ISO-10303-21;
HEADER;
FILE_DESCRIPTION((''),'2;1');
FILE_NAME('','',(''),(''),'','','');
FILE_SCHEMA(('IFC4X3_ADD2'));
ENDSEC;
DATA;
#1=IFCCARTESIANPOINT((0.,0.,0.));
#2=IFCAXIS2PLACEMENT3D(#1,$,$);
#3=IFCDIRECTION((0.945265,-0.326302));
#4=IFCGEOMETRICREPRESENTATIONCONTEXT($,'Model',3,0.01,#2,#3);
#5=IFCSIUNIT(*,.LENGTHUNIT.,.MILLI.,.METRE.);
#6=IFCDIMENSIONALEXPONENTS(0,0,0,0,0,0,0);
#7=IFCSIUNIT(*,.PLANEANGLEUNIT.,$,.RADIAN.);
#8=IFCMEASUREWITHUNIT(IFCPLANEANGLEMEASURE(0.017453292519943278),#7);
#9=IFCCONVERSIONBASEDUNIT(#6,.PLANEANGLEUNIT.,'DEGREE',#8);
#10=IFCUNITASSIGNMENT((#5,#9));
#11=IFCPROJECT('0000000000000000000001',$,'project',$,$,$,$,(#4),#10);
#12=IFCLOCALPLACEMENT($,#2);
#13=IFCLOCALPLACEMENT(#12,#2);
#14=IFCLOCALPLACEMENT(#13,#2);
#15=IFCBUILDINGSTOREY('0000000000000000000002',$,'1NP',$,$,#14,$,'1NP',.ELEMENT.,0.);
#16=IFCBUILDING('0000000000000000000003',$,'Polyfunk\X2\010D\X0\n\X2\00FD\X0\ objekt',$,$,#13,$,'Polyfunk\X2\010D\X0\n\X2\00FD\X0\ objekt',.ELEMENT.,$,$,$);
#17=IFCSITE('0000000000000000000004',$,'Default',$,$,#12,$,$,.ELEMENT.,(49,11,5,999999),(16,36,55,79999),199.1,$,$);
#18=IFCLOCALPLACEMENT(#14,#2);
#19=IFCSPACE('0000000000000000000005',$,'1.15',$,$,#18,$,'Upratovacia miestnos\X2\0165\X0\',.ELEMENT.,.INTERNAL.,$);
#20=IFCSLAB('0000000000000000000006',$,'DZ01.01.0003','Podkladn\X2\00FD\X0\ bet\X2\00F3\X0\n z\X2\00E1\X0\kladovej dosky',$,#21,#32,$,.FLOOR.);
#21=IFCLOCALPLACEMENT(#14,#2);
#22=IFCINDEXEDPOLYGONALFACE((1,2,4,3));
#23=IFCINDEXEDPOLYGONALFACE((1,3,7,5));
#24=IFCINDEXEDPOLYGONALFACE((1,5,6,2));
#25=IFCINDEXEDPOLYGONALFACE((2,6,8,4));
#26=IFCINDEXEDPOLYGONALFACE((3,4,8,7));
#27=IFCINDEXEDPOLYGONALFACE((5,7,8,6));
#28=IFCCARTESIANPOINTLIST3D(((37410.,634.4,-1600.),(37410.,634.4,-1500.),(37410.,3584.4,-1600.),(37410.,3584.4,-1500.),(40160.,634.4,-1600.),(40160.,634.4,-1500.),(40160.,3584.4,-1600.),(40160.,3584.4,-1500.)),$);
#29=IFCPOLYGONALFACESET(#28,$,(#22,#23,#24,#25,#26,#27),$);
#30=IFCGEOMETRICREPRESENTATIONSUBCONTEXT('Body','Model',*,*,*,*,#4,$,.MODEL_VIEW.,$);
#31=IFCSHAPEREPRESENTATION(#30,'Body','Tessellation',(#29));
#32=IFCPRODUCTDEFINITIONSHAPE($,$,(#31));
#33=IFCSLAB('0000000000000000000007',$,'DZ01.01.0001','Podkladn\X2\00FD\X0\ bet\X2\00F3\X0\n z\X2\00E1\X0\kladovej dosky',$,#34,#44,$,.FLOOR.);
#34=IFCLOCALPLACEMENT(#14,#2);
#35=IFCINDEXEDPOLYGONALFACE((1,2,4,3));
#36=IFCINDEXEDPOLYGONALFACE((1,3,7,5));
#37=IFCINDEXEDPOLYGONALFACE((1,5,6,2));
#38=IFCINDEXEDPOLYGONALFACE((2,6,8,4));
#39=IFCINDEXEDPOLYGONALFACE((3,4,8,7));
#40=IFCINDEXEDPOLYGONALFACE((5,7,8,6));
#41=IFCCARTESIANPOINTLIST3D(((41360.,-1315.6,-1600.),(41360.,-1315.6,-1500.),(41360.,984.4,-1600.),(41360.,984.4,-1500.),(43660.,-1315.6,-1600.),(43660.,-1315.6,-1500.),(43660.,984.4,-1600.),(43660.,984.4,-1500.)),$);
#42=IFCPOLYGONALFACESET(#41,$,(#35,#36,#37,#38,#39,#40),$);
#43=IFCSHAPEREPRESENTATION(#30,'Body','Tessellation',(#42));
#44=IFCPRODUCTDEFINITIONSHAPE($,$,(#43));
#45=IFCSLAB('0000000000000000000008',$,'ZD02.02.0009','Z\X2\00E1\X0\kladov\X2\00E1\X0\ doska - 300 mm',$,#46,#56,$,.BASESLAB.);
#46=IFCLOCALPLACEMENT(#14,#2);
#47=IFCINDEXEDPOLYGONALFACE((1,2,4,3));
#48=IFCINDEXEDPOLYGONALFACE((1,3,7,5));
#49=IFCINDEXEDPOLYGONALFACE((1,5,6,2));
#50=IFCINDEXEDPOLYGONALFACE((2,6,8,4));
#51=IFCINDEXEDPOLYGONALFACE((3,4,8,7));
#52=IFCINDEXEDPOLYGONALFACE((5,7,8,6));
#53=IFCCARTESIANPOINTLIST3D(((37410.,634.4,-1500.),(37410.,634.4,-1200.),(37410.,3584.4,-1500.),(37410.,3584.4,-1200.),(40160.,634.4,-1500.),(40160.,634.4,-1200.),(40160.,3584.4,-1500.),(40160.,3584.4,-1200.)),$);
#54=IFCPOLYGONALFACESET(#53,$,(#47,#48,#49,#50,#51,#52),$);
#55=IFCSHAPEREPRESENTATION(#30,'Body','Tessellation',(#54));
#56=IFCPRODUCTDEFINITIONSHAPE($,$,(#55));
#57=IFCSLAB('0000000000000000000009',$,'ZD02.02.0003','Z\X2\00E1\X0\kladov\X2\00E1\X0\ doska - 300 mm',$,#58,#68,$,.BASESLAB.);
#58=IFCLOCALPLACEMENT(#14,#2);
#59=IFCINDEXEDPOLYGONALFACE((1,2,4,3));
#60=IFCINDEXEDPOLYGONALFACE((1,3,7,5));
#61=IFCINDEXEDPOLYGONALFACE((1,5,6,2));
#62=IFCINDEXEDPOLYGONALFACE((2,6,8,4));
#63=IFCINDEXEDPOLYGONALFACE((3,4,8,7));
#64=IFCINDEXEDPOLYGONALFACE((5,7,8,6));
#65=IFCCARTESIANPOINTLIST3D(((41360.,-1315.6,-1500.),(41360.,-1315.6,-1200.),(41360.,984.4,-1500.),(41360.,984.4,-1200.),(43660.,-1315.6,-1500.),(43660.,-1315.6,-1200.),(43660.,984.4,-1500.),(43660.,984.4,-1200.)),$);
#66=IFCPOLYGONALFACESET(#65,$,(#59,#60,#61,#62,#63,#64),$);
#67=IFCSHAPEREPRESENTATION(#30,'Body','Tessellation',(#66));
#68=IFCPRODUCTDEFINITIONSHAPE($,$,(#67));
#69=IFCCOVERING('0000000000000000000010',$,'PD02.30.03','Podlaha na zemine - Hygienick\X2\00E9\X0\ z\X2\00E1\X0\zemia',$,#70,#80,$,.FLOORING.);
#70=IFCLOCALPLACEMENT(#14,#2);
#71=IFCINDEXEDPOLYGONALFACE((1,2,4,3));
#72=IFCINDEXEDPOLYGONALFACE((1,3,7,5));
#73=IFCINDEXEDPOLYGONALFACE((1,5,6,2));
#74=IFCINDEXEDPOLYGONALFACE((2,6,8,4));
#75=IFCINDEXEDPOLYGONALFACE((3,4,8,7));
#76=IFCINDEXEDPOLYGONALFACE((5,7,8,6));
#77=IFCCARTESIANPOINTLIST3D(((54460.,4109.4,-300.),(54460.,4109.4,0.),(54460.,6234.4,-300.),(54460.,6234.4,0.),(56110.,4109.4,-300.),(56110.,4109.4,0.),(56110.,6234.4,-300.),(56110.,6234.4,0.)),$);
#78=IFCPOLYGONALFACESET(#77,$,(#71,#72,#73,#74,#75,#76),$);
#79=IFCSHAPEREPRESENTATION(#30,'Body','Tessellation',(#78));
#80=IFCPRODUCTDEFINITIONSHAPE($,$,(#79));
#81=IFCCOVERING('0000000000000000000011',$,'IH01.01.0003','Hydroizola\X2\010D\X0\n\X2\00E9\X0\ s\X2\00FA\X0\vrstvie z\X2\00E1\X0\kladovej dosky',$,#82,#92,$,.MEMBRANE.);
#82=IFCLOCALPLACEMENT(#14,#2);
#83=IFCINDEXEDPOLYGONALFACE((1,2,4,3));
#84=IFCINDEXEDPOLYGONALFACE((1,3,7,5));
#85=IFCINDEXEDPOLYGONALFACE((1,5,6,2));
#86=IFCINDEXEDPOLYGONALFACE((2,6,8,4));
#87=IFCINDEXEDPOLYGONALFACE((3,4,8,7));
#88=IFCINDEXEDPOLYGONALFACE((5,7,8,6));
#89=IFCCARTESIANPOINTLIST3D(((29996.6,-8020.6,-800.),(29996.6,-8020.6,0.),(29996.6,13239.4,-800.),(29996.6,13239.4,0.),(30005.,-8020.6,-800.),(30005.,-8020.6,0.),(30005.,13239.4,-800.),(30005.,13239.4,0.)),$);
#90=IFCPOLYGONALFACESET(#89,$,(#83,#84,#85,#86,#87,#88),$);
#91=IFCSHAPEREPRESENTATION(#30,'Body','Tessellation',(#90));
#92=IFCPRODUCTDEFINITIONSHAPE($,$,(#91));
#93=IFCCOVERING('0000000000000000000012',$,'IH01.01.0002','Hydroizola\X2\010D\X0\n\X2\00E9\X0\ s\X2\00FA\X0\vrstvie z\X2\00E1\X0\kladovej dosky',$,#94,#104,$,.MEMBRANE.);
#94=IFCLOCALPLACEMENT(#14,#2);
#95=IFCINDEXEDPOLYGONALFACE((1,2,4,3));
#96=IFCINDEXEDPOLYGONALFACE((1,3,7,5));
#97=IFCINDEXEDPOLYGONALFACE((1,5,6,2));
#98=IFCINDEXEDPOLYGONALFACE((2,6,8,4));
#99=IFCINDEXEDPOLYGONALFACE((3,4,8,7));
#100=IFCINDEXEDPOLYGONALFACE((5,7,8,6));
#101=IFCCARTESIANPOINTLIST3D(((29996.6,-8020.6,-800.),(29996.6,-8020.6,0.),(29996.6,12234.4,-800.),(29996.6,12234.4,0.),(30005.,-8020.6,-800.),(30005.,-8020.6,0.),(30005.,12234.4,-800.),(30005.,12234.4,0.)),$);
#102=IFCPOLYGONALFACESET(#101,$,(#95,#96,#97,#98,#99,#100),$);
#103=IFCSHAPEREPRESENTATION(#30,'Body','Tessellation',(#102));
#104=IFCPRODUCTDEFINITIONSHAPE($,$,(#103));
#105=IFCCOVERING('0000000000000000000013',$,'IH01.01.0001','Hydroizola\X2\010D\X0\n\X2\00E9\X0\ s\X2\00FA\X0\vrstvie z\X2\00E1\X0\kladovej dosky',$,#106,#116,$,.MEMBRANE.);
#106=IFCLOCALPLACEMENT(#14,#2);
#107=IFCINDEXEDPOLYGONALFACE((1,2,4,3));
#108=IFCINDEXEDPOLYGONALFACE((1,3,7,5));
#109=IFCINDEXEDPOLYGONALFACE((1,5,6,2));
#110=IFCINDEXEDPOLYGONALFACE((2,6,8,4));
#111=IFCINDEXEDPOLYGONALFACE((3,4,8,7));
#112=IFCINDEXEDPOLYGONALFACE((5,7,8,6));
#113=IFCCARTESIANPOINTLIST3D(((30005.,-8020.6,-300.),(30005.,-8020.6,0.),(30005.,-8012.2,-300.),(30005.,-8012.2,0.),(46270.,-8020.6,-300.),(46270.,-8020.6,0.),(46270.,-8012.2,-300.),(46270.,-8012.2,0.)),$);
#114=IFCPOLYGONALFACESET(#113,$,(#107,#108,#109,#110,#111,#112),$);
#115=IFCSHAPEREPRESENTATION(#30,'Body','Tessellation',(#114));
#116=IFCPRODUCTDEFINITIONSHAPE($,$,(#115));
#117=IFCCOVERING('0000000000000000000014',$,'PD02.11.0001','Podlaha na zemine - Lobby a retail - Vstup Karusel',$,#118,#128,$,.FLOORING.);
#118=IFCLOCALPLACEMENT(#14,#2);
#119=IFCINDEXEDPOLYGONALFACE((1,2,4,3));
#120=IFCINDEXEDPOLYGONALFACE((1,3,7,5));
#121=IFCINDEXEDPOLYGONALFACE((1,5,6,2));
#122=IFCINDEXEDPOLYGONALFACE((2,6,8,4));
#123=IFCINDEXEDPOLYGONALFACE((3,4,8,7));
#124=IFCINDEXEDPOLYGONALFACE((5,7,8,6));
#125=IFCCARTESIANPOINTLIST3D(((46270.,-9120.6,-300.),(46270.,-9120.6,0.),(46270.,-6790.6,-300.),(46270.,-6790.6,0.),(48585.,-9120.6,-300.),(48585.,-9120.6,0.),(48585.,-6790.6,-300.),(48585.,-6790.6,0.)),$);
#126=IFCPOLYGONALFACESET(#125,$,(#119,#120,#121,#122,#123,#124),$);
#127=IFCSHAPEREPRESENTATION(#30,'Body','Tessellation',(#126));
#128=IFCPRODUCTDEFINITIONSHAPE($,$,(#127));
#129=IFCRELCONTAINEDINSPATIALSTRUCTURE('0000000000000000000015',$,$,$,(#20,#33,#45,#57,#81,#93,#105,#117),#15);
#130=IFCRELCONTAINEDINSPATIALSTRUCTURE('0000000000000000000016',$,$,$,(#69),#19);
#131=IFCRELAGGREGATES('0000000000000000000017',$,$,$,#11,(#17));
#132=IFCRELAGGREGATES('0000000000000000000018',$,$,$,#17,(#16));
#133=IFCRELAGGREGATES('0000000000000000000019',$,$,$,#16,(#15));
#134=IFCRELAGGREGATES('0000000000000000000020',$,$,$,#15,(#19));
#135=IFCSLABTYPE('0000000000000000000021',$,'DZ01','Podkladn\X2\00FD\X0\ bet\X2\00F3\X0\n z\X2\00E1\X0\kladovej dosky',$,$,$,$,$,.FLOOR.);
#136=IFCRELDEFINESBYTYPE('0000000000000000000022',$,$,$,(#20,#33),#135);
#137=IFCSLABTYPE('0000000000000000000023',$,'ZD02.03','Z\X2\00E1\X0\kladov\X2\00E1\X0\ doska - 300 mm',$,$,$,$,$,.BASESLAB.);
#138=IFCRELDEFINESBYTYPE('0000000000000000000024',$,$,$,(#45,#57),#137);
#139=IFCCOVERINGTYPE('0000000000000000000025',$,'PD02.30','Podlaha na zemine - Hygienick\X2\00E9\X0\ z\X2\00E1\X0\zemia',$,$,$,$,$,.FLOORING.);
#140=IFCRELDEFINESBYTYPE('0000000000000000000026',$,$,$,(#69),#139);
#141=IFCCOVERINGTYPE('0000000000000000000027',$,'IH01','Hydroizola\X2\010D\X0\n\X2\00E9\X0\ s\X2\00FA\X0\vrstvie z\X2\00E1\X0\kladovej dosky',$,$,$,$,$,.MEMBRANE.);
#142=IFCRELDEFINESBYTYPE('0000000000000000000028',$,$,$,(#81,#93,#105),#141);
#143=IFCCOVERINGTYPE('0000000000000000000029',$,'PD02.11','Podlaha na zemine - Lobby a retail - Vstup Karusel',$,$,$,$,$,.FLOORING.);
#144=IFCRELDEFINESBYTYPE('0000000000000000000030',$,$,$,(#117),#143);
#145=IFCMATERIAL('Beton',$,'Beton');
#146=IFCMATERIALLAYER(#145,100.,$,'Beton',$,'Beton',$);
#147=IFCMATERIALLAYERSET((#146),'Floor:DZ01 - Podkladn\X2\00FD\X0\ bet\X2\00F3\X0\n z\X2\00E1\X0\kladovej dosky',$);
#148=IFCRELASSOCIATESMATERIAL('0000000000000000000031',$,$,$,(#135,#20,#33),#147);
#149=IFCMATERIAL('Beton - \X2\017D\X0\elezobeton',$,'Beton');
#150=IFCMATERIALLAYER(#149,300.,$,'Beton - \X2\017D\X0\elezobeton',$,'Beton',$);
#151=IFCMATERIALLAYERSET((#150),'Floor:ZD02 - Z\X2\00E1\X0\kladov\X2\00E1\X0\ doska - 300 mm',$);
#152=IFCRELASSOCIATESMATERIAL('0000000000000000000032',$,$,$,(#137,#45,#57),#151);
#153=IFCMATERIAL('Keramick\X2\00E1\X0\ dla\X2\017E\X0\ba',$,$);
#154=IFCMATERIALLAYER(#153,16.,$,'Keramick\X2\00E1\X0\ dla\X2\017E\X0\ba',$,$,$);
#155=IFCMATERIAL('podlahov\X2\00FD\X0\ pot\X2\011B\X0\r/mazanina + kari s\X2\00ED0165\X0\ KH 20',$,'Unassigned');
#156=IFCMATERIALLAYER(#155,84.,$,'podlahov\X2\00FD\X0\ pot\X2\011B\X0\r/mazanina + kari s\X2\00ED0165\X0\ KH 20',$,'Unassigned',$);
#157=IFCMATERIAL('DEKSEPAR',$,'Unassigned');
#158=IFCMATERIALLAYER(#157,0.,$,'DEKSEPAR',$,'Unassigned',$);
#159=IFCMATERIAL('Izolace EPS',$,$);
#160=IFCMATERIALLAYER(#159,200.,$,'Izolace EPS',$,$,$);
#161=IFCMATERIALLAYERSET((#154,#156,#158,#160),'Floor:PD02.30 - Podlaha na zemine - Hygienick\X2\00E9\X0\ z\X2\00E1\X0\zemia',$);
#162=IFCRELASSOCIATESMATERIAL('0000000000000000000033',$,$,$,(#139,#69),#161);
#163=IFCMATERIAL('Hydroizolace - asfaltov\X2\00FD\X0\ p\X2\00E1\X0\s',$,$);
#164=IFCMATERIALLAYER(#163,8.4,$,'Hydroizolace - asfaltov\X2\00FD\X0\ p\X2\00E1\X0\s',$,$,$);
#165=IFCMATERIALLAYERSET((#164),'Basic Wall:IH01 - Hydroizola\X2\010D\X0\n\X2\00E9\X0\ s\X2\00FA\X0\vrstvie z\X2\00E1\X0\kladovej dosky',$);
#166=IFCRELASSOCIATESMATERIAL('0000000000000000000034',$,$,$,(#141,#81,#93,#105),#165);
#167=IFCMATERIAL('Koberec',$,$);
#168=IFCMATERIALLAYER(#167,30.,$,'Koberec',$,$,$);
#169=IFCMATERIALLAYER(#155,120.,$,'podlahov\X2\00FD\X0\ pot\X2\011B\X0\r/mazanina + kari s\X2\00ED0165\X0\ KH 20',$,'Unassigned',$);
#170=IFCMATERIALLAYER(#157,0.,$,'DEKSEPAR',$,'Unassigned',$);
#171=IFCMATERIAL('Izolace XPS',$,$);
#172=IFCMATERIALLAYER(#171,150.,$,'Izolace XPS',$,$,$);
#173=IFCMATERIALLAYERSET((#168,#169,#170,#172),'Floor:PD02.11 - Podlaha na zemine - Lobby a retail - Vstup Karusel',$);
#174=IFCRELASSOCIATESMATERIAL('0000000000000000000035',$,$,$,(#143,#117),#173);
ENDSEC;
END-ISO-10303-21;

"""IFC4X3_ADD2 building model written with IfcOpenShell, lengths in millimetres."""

from ifc_helpers import new_model, entity, si_unit, converted_unit, direction, frame, frame_2d, origin, place, context, subcontext, project, spatial, rectangle, extrude, material, layer, layer_set, layer_usage, type_object, element, save


model = new_model("IFC4X3_ADD2")

# Units and contexts
model_context = context("Model", 3, precision=0.01, world=origin(), true_north=direction((0.945265, -0.326302)))
body_context = subcontext(model_context, "Body", "Model", "MODEL_VIEW")
ifc_project = project(units=[si_unit("LENGTHUNIT", "METRE", prefix="MILLI"), converted_unit("PLANEANGLEUNIT", "DEGREE", entity("IfcPlaneAngleMeasure", 0.017453292519943278), si_unit("PLANEANGLEUNIT", "RADIAN"), dimensions=[0, 0, 0, 0, 0, 0, 0])], contexts=[model_context])

# Site, building, storey
site_placement = place(None, origin())
site = spatial("IfcSite", under=ifc_project, at=site_placement, Name="Default", CompositionType="ELEMENT", RefLatitude=(49, 11, 5, 999999), RefLongitude=(16, 36, 55, 79999), RefElevation=199.1)
building_placement = place(site_placement, origin())
building = spatial("IfcBuilding", under=site, at=building_placement, Name="Polyfunkčný objekt", LongName="Polyfunkčný objekt", CompositionType="ELEMENT")
storey_placement = place(building_placement, origin())
storey = spatial("IfcBuildingStorey", under=building, at=storey_placement, Name="1NP", LongName="1NP", CompositionType="ELEMENT", Elevation=0.0)

# Shared definitions
ifc_material_1 = material(Name="Beton", Category="Beton")
ifc_layer_1 = layer(ifc_material_1, 100.0, Name="Beton", Category="Beton")
ifc_layer_set_1 = layer_set([ifc_layer_1], Name="Floor:DZ01 - Podkladný betón základovej dosky")
slab_type_1 = type_object("IfcSlabType", Name="DZ01", Description="Podkladný betón základovej dosky", PredefinedType="FLOOR", material=ifc_layer_set_1)

# Slabs
ifc_layer_usage_1 = layer_usage(ifc_layer_set_1, "AXIS3", "POSITIVE", 0.0)
slab_1_placement = place(storey_placement, origin())
element("IfcSlab", 1, at=slab_1_placement, inside=storey, type_object=slab_type_1, material=ifc_layer_usage_1, Name="DZ01.01.0003", Description="Podkladný betón základovej dosky", PredefinedType="FLOOR", context=body_context, shape_type="SweptSolid", body=[
    extrude(rectangle(XDim=2950.0, YDim=2750.0, at=frame_2d((0.0, 0.0), x_axis=(1.0, 0.0))), frame((38785.0, 2109.4, -1500.0), z_axis=(0.0, 0.0, -1.0), x_axis=(0.0, 1.0, 0.0)), (0.0, 0.0, 1.0), 100.0),
])
ifc_layer_usage_2 = layer_usage(ifc_layer_set_1, "AXIS3", "POSITIVE", 0.0)
slab_2_placement = place(storey_placement, origin())
element("IfcSlab", 2, at=slab_2_placement, inside=storey, type_object=slab_type_1, material=ifc_layer_usage_2, Name="DZ01.01.0001", Description="Podkladný betón základovej dosky", PredefinedType="FLOOR", context=body_context, shape_type="SweptSolid", body=[
    extrude(rectangle(XDim=2300.0, YDim=2300.0, at=frame_2d((0.0, 0.0), x_axis=(1.0, 0.0))), frame((42510.0, -165.6, -1500.0), z_axis=(0.0, 0.0, -1.0), x_axis=(0.0, 1.0, 0.0)), (0.0, 0.0, 1.0), 100.0),
])
ifc_material_2 = material(Name="Beton - Železobeton", Category="Beton")
ifc_layer_2 = layer(ifc_material_2, 300.0, Name="Beton - Železobeton", Category="Beton")
ifc_layer_set_2 = layer_set([ifc_layer_2], Name="Floor:ZD02 - Základová doska - 300 mm")
ifc_layer_usage_3 = layer_usage(ifc_layer_set_2, "AXIS3", "POSITIVE", 0.0)
slab_type_2 = type_object("IfcSlabType", Name="ZD02.03", Description="Základová doska - 300 mm", PredefinedType="BASESLAB", material=ifc_layer_set_2)
slab_3_placement = place(storey_placement, origin())
element("IfcSlab", 3, at=slab_3_placement, inside=storey, type_object=slab_type_2, material=ifc_layer_usage_3, Name="ZD02.02.0009", Description="Základová doska - 300 mm", PredefinedType="BASESLAB", context=body_context, shape_type="SweptSolid", body=[
    extrude(rectangle(XDim=2950.0, YDim=2750.0, at=frame_2d((0.0, 0.0), x_axis=(1.0, 0.0))), frame((38785.0, 2109.4, -1200.0), z_axis=(0.0, 0.0, -1.0), x_axis=(0.0, 1.0, 0.0)), (0.0, 0.0, 1.0), 300.0),
])
ifc_layer_usage_4 = layer_usage(ifc_layer_set_2, "AXIS3", "POSITIVE", 0.0)
slab_4_placement = place(storey_placement, origin())
element("IfcSlab", 4, at=slab_4_placement, inside=storey, type_object=slab_type_2, material=ifc_layer_usage_4, Name="ZD02.02.0003", Description="Základová doska - 300 mm", PredefinedType="BASESLAB", context=body_context, shape_type="SweptSolid", body=[
    extrude(rectangle(XDim=2300.0, YDim=2300.0, at=frame_2d((0.0, 0.0), x_axis=(1.0, 0.0))), frame((42510.0, -165.6, -1200.0), z_axis=(0.0, 0.0, -1.0), x_axis=(0.0, 1.0, 0.0)), (0.0, 0.0, 1.0), 300.0),
])

# Shared definitions
ifc_material_3 = material(Name="podlahový potěr/mazanina + kari síť KH 20", Category="Unassigned")
ifc_material_4 = material(Name="DEKSEPAR", Category="Unassigned")
ifc_material_5 = material(Name="Izolace EPS")

# Shared definitions
ifc_material_6 = material(Name="Keramická dlažba")
ifc_layer_3 = layer(ifc_material_6, 16.0, Name="Keramická dlažba")
ifc_layer_4 = layer(ifc_material_3, 84.0, Name="podlahový potěr/mazanina + kari síť KH 20", Category="Unassigned")
ifc_layer_5 = layer(ifc_material_4, 0.0, Name="DEKSEPAR", Category="Unassigned")
ifc_layer_6 = layer(ifc_material_5, 200.0, Name="Izolace EPS")
ifc_layer_set_3 = layer_set([ifc_layer_3, ifc_layer_4, ifc_layer_5, ifc_layer_6], Name="Floor:PD02.30 - Podlaha na zemine - Hygienické zázemia")
covering_type_1 = type_object("IfcCoveringType", Name="PD02.30", Description="Podlaha na zemine - Hygienické zázemia", PredefinedType="FLOORING", material=ifc_layer_set_3)

# Shared definitions
space_1_placement = place(storey_placement, origin())
space_1 = spatial("IfcSpace", under=storey, at=space_1_placement, Name="1.15", LongName="Upratovacia miestnosť", CompositionType="ELEMENT", PredefinedType="INTERNAL")

# Covering
ifc_layer_usage_5 = layer_usage(ifc_layer_set_3, "AXIS3", "POSITIVE", 0.0)
covering_1_placement = place(storey_placement, origin())
element("IfcCovering", 5, at=covering_1_placement, inside=space_1, type_object=covering_type_1, material=ifc_layer_usage_5, Name="PD02.30.03", Description="Podlaha na zemine - Hygienické zázemia", PredefinedType="FLOORING", context=body_context, shape_type="SweptSolid", body=[
    extrude(rectangle(XDim=2125.0, YDim=1650.0, at=frame_2d((0.0, 0.0), x_axis=(1.0, 0.0))), frame((55285.0, 5171.9, 0.0), z_axis=(0.0, 0.0, -1.0), x_axis=(0.0, 1.0, 0.0)), (0.0, 0.0, 1.0), 300.0),
])

# Coverings
ifc_material_7 = material(Name="Hydroizolace - asfaltový pás")
ifc_layer_7 = layer(ifc_material_7, 8.4, Name="Hydroizolace - asfaltový pás")
ifc_layer_set_4 = layer_set([ifc_layer_7], Name="Basic Wall:IH01 - Hydroizolačné súvrstvie základovej dosky")
covering_type_2 = type_object("IfcCoveringType", Name="IH01", Description="Hydroizolačné súvrstvie základovej dosky", PredefinedType="MEMBRANE", material=ifc_layer_set_4)
covering_2_placement = place(storey_placement, frame((30000.8, -8020.6, -800.0), z_axis=(0.0, 0.0, 1.0), x_axis=(0.0, 1.0, 0.0)))
element("IfcCovering", 6, at=covering_2_placement, inside=storey, type_object=covering_type_2, material=ifc_layer_set_4, Name="IH01.01.0003", Description="Hydroizolačné súvrstvie základovej dosky", PredefinedType="MEMBRANE", context=body_context, shape_type="SweptSolid", body=[
    extrude(rectangle(XDim=21260.0, YDim=8.4, at=frame_2d((10630.0, 0.0), x_axis=(-1.0, 0.0))), origin(), (0.0, 0.0, 1.0), 800.0),
])
covering_3_placement = place(storey_placement, frame((30000.8, -8020.6, -800.0), z_axis=(0.0, 0.0, 1.0), x_axis=(0.0, 1.0, 0.0)))
element("IfcCovering", 7, at=covering_3_placement, inside=storey, type_object=covering_type_2, material=ifc_layer_set_4, Name="IH01.01.0002", Description="Hydroizolačné súvrstvie základovej dosky", PredefinedType="MEMBRANE", context=body_context, shape_type="SweptSolid", body=[
    extrude(rectangle(XDim=20255.0, YDim=8.4, at=frame_2d((10127.5, 0.0), x_axis=(-1.0, 0.0))), origin(), (0.0, 0.0, 1.0), 800.0),
])
covering_4_placement = place(storey_placement, frame((30005.0, -8016.4, -300.0)))
element("IfcCovering", 8, at=covering_4_placement, inside=storey, type_object=covering_type_2, material=ifc_layer_set_4, Name="IH01.01.0001", Description="Hydroizolačné súvrstvie základovej dosky", PredefinedType="MEMBRANE", context=body_context, shape_type="SweptSolid", body=[
    extrude(rectangle(XDim=16265.0, YDim=8.4, at=frame_2d((8132.5, 0.0), x_axis=(-1.0, 0.0))), origin(), (0.0, 0.0, 1.0), 300.0),
])
ifc_material_8 = material(Name="Koberec")
ifc_layer_8 = layer(ifc_material_8, 30.0, Name="Koberec")
ifc_layer_9 = layer(ifc_material_3, 120.0, Name="podlahový potěr/mazanina + kari síť KH 20", Category="Unassigned")
ifc_layer_10 = layer(ifc_material_4, 0.0, Name="DEKSEPAR", Category="Unassigned")
ifc_material_9 = material(Name="Izolace XPS")
ifc_layer_11 = layer(ifc_material_9, 150.0, Name="Izolace XPS")
ifc_layer_set_5 = layer_set([ifc_layer_8, ifc_layer_9, ifc_layer_10, ifc_layer_11], Name="Floor:PD02.11 - Podlaha na zemine - Lobby a retail - Vstup Karusel")
ifc_layer_usage_6 = layer_usage(ifc_layer_set_5, "AXIS3", "POSITIVE", 0.0)
covering_type_3 = type_object("IfcCoveringType", Name="PD02.11", Description="Podlaha na zemine - Lobby a retail - Vstup Karusel", PredefinedType="FLOORING", material=ifc_layer_set_5)
covering_5_placement = place(storey_placement, origin())
element("IfcCovering", 9, at=covering_5_placement, inside=storey, type_object=covering_type_3, material=ifc_layer_usage_6, Name="PD02.11.0001", Description="Podlaha na zemine - Lobby a retail - Vstup Karusel", PredefinedType="FLOORING", context=body_context, shape_type="SweptSolid", body=[
    extrude(rectangle(XDim=2330.0, YDim=2315.0, at=frame_2d((0.0, 0.0), x_axis=(1.0, 0.0))), frame((47427.5, -7955.6, 0.0), z_axis=(0.0, 0.0, -1.0), x_axis=(0.0, 1.0, 0.0)), (0.0, 0.0, 1.0), 300.0),
])

save(model, "model.ifc")
